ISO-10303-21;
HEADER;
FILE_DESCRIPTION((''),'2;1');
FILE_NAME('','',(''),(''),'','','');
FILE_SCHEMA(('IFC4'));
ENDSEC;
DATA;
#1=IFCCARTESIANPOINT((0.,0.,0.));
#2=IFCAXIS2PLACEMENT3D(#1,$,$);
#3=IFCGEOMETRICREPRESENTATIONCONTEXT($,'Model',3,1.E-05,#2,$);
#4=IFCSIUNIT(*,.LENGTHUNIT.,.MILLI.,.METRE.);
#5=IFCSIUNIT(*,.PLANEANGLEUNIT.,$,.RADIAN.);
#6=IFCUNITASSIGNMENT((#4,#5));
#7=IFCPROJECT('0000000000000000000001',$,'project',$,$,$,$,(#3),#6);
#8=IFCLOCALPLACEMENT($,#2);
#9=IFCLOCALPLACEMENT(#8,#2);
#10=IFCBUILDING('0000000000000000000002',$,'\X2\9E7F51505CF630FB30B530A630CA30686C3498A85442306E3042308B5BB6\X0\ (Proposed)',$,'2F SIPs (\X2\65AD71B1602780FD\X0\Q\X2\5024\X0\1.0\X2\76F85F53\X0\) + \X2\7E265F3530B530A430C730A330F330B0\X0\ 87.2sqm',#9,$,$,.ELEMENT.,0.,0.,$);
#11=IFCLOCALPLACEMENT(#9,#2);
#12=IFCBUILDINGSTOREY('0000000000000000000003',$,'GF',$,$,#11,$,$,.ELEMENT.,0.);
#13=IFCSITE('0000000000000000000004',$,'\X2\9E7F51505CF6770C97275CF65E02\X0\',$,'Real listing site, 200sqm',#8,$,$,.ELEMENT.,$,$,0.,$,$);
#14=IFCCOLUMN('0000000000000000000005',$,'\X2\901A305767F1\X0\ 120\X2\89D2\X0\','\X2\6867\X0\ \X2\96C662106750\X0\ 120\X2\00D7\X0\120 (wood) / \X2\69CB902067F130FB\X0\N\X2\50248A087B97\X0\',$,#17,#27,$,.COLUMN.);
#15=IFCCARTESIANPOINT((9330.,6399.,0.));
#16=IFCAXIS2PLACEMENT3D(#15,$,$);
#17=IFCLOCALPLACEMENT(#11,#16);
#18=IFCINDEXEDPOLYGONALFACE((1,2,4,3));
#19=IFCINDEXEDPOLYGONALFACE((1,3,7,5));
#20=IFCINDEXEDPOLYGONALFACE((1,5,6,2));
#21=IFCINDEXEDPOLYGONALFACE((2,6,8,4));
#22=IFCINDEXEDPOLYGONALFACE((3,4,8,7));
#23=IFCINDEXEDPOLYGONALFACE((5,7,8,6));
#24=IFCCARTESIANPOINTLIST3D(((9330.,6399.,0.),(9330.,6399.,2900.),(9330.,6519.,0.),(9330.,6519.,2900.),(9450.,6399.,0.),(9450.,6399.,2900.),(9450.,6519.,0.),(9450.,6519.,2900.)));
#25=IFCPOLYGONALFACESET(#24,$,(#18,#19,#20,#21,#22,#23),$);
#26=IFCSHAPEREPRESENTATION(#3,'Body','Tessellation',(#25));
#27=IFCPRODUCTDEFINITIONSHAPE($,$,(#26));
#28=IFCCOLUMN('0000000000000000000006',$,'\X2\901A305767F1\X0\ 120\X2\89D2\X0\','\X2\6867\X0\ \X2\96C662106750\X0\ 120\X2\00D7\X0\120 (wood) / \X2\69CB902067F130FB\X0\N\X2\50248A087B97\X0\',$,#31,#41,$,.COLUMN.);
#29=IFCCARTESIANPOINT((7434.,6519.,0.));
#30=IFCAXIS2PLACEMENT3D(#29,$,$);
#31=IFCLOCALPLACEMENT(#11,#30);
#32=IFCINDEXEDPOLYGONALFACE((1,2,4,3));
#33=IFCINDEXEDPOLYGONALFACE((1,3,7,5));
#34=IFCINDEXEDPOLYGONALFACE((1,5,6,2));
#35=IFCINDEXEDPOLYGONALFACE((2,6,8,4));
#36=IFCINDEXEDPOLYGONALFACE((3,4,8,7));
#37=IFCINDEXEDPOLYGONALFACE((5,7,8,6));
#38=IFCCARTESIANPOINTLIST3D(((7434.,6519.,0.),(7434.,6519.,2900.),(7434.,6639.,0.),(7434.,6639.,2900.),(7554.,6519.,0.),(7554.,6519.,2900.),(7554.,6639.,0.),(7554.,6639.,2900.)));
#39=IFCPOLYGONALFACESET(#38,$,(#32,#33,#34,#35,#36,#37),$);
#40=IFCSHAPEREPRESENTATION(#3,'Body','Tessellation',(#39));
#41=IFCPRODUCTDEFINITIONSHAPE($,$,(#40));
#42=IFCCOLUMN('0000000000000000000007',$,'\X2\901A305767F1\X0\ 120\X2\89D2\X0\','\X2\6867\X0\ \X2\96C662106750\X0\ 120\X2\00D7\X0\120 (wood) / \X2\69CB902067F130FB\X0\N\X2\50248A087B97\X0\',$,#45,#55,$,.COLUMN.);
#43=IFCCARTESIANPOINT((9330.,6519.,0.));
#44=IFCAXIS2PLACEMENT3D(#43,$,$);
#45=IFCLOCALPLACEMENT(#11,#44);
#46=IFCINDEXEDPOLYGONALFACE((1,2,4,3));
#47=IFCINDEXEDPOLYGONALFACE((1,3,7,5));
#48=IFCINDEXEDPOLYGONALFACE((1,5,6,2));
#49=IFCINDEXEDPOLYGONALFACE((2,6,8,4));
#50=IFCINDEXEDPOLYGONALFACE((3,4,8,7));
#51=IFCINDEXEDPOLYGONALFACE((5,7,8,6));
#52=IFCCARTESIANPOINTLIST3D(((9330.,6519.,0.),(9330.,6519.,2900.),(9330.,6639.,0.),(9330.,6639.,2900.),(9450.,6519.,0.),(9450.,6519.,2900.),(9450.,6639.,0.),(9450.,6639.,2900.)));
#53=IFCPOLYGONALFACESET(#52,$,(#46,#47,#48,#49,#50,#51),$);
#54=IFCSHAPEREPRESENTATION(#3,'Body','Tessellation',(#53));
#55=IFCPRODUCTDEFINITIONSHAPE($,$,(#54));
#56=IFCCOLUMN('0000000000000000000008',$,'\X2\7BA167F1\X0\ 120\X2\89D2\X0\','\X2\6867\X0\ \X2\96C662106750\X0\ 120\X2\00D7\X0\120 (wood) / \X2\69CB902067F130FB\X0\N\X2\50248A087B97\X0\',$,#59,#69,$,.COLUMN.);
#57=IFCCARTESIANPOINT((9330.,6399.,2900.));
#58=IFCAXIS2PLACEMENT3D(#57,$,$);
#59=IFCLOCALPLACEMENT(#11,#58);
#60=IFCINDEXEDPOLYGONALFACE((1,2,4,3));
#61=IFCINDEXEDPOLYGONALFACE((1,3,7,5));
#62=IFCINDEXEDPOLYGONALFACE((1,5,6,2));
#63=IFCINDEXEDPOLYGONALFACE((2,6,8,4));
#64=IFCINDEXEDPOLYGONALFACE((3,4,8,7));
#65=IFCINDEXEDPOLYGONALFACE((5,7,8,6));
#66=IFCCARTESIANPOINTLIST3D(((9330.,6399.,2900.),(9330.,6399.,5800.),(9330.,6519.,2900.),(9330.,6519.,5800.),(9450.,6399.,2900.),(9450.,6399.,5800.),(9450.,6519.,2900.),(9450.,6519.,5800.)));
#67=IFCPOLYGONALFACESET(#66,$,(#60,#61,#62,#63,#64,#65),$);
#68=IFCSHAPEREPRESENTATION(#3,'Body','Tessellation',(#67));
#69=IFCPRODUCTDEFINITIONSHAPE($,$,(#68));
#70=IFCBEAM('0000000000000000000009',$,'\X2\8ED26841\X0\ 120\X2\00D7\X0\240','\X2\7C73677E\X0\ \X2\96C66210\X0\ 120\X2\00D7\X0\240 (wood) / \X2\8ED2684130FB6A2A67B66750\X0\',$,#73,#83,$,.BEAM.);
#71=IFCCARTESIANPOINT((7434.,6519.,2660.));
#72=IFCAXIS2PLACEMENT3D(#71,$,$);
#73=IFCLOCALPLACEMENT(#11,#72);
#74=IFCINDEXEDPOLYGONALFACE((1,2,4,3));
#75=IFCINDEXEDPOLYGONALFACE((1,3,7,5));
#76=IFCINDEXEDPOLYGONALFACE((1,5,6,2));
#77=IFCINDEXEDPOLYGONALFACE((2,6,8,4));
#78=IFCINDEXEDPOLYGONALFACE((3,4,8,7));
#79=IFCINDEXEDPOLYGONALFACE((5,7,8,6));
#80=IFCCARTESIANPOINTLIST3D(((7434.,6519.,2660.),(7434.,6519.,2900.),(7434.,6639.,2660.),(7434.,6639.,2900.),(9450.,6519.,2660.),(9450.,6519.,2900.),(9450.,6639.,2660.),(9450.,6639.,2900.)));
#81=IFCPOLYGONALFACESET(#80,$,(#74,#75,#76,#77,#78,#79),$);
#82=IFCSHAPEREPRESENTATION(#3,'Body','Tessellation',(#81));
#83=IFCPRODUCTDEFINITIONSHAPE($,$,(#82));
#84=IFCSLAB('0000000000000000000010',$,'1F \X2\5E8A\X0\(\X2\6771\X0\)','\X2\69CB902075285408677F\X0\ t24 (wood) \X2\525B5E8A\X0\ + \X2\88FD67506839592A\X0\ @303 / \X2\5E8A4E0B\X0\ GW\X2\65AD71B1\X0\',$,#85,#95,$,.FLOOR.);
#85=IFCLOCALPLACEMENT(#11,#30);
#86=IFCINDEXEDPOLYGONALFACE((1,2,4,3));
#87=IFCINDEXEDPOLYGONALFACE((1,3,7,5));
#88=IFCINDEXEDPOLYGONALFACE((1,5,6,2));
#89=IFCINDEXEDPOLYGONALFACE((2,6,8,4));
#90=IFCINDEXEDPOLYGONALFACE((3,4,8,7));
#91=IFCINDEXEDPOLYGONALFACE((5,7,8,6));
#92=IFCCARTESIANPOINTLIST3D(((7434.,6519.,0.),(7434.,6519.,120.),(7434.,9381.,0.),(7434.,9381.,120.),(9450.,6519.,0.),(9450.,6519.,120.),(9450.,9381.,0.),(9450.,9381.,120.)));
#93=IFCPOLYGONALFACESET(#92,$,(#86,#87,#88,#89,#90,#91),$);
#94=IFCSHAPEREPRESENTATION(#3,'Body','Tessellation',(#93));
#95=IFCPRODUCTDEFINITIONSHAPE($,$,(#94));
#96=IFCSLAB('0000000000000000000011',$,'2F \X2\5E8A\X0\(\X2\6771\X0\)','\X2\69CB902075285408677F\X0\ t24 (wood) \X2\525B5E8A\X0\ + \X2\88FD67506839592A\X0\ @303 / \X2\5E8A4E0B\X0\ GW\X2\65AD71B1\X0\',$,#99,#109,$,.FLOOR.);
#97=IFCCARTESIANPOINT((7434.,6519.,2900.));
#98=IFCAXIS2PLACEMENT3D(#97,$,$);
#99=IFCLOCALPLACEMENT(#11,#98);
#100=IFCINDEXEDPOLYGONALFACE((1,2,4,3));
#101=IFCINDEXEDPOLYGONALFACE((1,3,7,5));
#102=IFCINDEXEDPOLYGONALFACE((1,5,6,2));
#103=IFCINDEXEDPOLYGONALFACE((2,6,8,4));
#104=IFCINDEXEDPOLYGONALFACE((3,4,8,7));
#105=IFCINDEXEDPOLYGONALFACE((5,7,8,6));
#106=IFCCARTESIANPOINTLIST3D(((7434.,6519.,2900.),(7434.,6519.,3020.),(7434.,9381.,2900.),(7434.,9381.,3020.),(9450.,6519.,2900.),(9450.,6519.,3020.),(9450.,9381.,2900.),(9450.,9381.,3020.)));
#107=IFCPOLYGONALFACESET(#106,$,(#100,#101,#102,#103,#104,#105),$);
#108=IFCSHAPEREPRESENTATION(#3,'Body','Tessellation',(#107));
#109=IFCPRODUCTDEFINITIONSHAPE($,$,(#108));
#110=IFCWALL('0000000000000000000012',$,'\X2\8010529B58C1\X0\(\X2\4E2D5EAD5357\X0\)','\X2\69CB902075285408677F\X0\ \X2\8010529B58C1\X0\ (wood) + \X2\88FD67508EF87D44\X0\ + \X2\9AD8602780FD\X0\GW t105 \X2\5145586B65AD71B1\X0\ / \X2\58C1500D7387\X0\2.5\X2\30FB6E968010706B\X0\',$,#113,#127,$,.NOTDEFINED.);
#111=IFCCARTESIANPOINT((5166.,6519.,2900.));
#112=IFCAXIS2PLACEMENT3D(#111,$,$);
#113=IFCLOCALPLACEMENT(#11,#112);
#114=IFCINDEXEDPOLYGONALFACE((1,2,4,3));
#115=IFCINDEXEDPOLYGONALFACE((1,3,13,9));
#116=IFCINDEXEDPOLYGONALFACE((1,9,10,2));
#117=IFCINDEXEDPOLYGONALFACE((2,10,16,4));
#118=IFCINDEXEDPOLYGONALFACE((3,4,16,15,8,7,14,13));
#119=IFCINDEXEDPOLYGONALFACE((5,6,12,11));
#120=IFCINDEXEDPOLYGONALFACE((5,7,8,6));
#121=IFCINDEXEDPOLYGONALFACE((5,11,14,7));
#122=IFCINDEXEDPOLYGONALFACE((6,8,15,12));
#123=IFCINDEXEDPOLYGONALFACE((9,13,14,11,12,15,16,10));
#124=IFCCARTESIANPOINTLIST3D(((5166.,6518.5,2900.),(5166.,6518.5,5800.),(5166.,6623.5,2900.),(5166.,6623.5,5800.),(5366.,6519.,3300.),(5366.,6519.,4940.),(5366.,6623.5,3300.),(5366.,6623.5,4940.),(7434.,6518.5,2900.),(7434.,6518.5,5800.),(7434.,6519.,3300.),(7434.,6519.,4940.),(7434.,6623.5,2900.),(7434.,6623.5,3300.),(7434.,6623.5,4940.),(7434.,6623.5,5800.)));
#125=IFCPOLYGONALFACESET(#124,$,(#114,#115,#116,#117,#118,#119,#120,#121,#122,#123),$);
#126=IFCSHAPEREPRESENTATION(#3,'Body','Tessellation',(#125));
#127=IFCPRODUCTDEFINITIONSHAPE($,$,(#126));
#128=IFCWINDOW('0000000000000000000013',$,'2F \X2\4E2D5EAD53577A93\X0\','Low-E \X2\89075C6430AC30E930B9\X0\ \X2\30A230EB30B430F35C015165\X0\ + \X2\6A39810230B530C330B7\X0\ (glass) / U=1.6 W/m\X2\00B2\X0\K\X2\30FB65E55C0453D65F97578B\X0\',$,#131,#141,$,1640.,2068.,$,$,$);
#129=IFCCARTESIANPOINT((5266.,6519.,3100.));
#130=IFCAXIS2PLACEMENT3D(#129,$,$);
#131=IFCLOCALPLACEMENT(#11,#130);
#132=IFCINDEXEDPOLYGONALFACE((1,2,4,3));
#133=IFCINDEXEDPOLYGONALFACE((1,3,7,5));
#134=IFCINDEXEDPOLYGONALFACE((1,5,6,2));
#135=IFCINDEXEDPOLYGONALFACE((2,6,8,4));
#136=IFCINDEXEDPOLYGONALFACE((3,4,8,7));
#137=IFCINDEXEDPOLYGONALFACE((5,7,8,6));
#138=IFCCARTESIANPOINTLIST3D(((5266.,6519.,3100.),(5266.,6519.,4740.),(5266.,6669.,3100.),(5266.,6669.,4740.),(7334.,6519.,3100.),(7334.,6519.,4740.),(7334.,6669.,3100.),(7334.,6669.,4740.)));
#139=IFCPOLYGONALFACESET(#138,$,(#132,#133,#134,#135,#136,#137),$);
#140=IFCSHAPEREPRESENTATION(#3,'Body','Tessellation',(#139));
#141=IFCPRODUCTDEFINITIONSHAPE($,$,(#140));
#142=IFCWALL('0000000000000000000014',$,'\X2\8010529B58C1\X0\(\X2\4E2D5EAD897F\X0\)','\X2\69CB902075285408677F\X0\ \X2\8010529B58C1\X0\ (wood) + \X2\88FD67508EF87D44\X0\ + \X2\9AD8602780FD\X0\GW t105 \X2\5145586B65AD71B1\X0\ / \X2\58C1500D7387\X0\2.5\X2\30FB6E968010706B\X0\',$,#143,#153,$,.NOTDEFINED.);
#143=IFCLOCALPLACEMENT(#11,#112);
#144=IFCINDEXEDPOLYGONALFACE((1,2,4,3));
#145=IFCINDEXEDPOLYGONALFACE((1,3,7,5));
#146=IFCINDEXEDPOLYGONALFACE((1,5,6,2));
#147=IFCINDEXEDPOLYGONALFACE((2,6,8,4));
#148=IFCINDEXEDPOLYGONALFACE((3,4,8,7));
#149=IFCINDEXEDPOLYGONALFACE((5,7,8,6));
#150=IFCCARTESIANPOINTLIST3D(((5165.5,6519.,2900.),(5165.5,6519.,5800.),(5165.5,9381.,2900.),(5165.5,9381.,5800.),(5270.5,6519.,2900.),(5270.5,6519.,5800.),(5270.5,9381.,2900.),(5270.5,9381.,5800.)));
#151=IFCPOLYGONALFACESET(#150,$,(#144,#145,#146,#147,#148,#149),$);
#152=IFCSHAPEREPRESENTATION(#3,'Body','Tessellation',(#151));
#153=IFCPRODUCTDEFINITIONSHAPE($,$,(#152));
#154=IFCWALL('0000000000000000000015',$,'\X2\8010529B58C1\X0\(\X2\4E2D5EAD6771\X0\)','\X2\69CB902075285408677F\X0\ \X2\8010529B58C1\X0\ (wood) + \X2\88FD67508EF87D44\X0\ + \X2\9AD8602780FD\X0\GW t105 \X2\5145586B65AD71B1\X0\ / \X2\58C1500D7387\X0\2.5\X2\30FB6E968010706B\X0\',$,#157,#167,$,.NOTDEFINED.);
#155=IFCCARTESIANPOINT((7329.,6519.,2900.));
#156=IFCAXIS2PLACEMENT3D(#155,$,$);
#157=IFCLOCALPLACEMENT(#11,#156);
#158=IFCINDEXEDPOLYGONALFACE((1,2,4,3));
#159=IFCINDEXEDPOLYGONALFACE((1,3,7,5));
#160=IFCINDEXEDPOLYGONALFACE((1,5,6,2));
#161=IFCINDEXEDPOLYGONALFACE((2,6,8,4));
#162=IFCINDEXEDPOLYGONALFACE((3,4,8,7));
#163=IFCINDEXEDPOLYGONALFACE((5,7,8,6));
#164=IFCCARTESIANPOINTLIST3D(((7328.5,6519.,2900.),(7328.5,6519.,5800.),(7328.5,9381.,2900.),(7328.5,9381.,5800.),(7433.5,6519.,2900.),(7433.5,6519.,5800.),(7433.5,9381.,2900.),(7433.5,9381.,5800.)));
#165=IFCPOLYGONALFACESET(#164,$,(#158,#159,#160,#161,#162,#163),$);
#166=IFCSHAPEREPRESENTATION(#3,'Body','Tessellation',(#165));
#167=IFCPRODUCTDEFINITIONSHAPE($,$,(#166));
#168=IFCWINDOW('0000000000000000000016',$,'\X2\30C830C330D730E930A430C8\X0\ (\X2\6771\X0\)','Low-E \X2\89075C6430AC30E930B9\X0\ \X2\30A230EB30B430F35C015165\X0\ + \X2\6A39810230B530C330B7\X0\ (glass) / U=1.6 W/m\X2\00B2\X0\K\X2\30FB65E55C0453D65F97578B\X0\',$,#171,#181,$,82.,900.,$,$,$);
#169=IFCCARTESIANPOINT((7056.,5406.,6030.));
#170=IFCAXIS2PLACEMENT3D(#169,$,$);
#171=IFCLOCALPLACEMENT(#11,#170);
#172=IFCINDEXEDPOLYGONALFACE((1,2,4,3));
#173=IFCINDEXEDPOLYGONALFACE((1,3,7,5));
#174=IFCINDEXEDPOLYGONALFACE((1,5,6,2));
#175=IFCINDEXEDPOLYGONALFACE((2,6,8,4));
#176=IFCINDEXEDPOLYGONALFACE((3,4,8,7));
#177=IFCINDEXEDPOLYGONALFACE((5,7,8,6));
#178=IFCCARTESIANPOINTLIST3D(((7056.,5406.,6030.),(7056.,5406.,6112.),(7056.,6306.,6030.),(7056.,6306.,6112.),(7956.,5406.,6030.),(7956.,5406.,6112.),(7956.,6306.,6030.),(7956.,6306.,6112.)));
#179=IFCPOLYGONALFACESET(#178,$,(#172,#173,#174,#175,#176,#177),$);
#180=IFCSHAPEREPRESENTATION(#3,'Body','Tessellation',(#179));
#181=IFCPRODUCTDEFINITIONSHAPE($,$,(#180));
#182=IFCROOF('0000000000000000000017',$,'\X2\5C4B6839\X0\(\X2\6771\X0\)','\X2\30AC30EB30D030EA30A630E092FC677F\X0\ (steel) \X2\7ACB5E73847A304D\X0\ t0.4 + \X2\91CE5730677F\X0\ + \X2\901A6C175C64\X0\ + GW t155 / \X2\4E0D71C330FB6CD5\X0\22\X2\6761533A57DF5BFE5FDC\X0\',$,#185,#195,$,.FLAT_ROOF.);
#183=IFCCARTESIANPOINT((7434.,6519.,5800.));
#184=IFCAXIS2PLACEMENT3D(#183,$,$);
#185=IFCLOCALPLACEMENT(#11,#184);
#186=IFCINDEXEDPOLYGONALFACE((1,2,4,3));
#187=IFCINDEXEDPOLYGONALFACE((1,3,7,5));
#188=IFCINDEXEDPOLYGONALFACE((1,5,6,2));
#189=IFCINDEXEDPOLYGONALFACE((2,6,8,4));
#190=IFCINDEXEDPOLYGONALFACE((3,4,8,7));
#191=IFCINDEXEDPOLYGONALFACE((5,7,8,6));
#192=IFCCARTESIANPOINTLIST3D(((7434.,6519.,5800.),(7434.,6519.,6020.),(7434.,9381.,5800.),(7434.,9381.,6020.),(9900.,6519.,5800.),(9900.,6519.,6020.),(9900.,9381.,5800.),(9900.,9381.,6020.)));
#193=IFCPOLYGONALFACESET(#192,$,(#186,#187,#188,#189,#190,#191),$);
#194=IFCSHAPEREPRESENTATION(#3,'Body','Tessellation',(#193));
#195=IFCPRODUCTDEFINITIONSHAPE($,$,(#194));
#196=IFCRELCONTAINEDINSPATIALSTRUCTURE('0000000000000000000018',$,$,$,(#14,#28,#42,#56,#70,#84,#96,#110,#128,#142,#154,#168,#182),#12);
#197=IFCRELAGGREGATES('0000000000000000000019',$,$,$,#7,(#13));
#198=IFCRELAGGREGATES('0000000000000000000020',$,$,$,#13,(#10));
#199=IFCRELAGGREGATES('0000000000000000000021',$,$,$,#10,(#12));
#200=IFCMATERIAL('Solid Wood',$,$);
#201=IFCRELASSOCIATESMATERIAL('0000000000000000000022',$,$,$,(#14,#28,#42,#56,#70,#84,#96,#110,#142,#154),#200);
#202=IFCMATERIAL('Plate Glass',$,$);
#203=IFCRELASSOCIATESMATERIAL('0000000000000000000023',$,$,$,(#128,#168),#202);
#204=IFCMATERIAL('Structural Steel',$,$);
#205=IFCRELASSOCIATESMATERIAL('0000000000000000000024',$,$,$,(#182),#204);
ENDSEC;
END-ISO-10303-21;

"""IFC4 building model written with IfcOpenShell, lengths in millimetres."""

from ifc_helpers import new_model, si_unit, frame, frame_2d, origin, place, context, project, spatial, rectangle, extrude, material, element, fill, save


model = new_model("IFC4")

# Units and contexts
model_context = context("Model", 3, precision=1e-05, world=origin())
ifc_project = project(units=[si_unit("LENGTHUNIT", "METRE", prefix="MILLI"), si_unit("PLANEANGLEUNIT", "RADIAN")], contexts=[model_context])

# Site, building, storey
site_placement = place(None, origin())
site = spatial("IfcSite", under=ifc_project, at=site_placement, Name="鹿児島県霧島市", ObjectType="Real listing site, 200sqm", CompositionType="ELEMENT", RefElevation=0.0)
building_placement = place(site_placement, origin())
building = spatial("IfcBuilding", under=site, at=building_placement, Name="鹿児島・サウナと水風呂のある家 (Proposed)", ObjectType="2F SIPs (断熱性能Q値1.0相当) + 縦張サイディング 87.2sqm", CompositionType="ELEMENT", ElevationOfRefHeight=0.0, ElevationOfTerrain=0.0)
storey_placement = place(building_placement, origin())
storey = spatial("IfcBuildingStorey", under=building, at=storey_placement, Name="GF", CompositionType="ELEMENT", Elevation=0.0)

# Columns
ifc_material_1 = material(Name="Solid Wood")
column_1_placement = place(storey_placement, frame((9330.0, 6399.0, 0.0)))
element("IfcColumn", 1, at=column_1_placement, inside=storey, material=ifc_material_1, Name="通し柱 120角", Description="桧 集成材 120×120 (wood) / 構造柱・N値計算", PredefinedType="COLUMN", context=model_context, shape_type="SweptSolid", body=[
    extrude(rectangle(XDim=120.0, YDim=120.0, at=frame_2d((60.0, 60.0))), frame((9330.0, 6399.0, 0.0)), (0.0, 0.0, 1.0), 2900.0),
])
column_2_placement = place(storey_placement, frame((7434.0, 6519.0, 0.0)))
element("IfcColumn", 2, at=column_2_placement, inside=storey, material=ifc_material_1, Name="通し柱 120角", Description="桧 集成材 120×120 (wood) / 構造柱・N値計算", PredefinedType="COLUMN", context=model_context, shape_type="SweptSolid", body=[
    extrude(rectangle(XDim=120.0, YDim=120.0, at=frame_2d((60.0, 60.0))), frame((7434.0, 6519.0, 0.0)), (0.0, 0.0, 1.0), 2900.0),
])
column_3_placement = place(storey_placement, frame((9330.0, 6519.0, 0.0)))
element("IfcColumn", 3, at=column_3_placement, inside=storey, material=ifc_material_1, Name="通し柱 120角", Description="桧 集成材 120×120 (wood) / 構造柱・N値計算", PredefinedType="COLUMN", context=model_context, shape_type="SweptSolid", body=[
    extrude(rectangle(XDim=120.0, YDim=120.0, at=frame_2d((60.0, 60.0))), frame((9330.0, 6519.0, 0.0)), (0.0, 0.0, 1.0), 2900.0),
])
column_4_placement = place(storey_placement, frame((9330.0, 6399.0, 2900.0)))
element("IfcColumn", 4, at=column_4_placement, inside=storey, material=ifc_material_1, Name="管柱 120角", Description="桧 集成材 120×120 (wood) / 構造柱・N値計算", PredefinedType="COLUMN", context=model_context, shape_type="SweptSolid", body=[
    extrude(rectangle(XDim=120.0, YDim=120.0, at=frame_2d((60.0, 60.0))), frame((9330.0, 6399.0, 2900.0)), (0.0, 0.0, 1.0), 2900.0),
])

# Beam
beam_1_placement = place(storey_placement, frame((7434.0, 6519.0, 2660.0)))
element("IfcBeam", 5, at=beam_1_placement, inside=storey, material=ifc_material_1, Name="軒桁 120×240", Description="米松 集成 120×240 (wood) / 軒桁・横架材", PredefinedType="BEAM", context=model_context, shape_type="SweptSolid", body=[
    extrude(rectangle(XDim=2016.0, YDim=120.0, at=frame_2d((1008.0, 60.0))), frame((7434.0, 6519.0, 2660.0)), (0.0, 0.0, 1.0), 240.0),
])

# Slabs
slab_1_placement = place(storey_placement, frame((7434.0, 6519.0, 0.0)))
element("IfcSlab", 6, at=slab_1_placement, inside=storey, material=ifc_material_1, Name="1F 床(東)", Description="構造用合板 t24 (wood) 剛床 + 製材根太 @303 / 床下 GW断熱", PredefinedType="FLOOR", context=model_context, shape_type="SweptSolid", body=[
    extrude(rectangle(XDim=2016.0, YDim=2862.0, at=frame_2d((1008.0, 1431.0))), frame((7434.0, 6519.0, 0.0)), (0.0, 0.0, 1.0), 120.0),
])
slab_2_placement = place(storey_placement, frame((7434.0, 6519.0, 2900.0)))
element("IfcSlab", 7, at=slab_2_placement, inside=storey, material=ifc_material_1, Name="2F 床(東)", Description="構造用合板 t24 (wood) 剛床 + 製材根太 @303 / 床下 GW断熱", PredefinedType="FLOOR", context=model_context, shape_type="SweptSolid", body=[
    extrude(rectangle(XDim=2016.0, YDim=2862.0, at=frame_2d((1008.0, 1431.0))), frame((7434.0, 6519.0, 2900.0)), (0.0, 0.0, 1.0), 120.0),
])

# Wall, opening, window
wall_1_placement = place(storey_placement, frame((5166.0, 6519.0, 2900.0)))
wall_1 = element("IfcWall", 8, at=wall_1_placement, inside=storey, material=ifc_material_1, Name="耐力壁(中庭南)", Description="構造用合板 耐力壁 (wood) + 製材軸組 + 高性能GW t105 充填断熱 / 壁倍率2.5・準耐火", PredefinedType="NOTDEFINED", context=model_context, shape_type="SweptSolid", body=[
    extrude(rectangle(XDim=2268.0, YDim=105.0, at=frame_2d((1134.0, 52.0))), frame((5166.0, 6519.0, 2900.0)), (0.0, 0.0, 1.0), 2900.0),
])
opening_placement = place(storey_placement, frame((5266.0, 6519.0, 3100.0)))
opening = element("IfcOpeningElement", 9, at=opening_placement, cuts=wall_1, PredefinedType="NOTDEFINED", context=model_context, shape_type="SweptSolid", body=[
    extrude(rectangle(XDim=2068.0, YDim=150.0, at=frame_2d((1034.0, 75.0))), frame((5266.0, 6519.0, 3100.0)), (0.0, 0.0, 1.0), 1640.0),
])
ifc_material_2 = material(Name="Plate Glass")
window_1_placement = place(storey_placement, frame((5266.0, 6519.0, 3100.0)))
window_1 = element("IfcWindow", 10, at=window_1_placement, inside=storey, material=ifc_material_2, Name="2F 中庭南窓", Description="Low-E 複層ガラス アルゴン封入 + 樹脂サッシ (glass) / U=1.6 W/m²K・日射取得型", OverallHeight=1640.0, OverallWidth=2068.0, context=model_context, shape_type="SweptSolid", body=[
    extrude(rectangle(XDim=2068.0, YDim=150.0, at=frame_2d((1034.0, 75.0))), frame((5266.0, 6519.0, 3100.0)), (0.0, 0.0, 1.0), 1640.0),
])
fill(opening, window_1)

# Walls
wall_2_placement = place(storey_placement, frame((5166.0, 6519.0, 2900.0)))
element("IfcWall", 11, at=wall_2_placement, inside=storey, material=ifc_material_1, Name="耐力壁(中庭西)", Description="構造用合板 耐力壁 (wood) + 製材軸組 + 高性能GW t105 充填断熱 / 壁倍率2.5・準耐火", PredefinedType="NOTDEFINED", context=model_context, shape_type="SweptSolid", body=[
    extrude(rectangle(XDim=105.0, YDim=2862.0, at=frame_2d((52.0, 1431.0))), frame((5166.0, 6519.0, 2900.0)), (0.0, 0.0, 1.0), 2900.0),
])
wall_3_placement = place(storey_placement, frame((7329.0, 6519.0, 2900.0)))
element("IfcWall", 12, at=wall_3_placement, inside=storey, material=ifc_material_1, Name="耐力壁(中庭東)", Description="構造用合板 耐力壁 (wood) + 製材軸組 + 高性能GW t105 充填断熱 / 壁倍率2.5・準耐火", PredefinedType="NOTDEFINED", context=model_context, shape_type="SweptSolid", body=[
    extrude(rectangle(XDim=105.0, YDim=2862.0, at=frame_2d((52.0, 1431.0))), frame((7329.0, 6519.0, 2900.0)), (0.0, 0.0, 1.0), 2900.0),
])

# Window
window_2_placement = place(storey_placement, frame((7056.0, 5406.0, 6030.0)))
element("IfcWindow", 13, at=window_2_placement, inside=storey, material=ifc_material_2, Name="トップライト (東)", Description="Low-E 複層ガラス アルゴン封入 + 樹脂サッシ (glass) / U=1.6 W/m²K・日射取得型", OverallHeight=82.0, OverallWidth=900.0, context=model_context, shape_type="SweptSolid", body=[
    extrude(rectangle(XDim=900.0, YDim=900.0, at=frame_2d((450.0, 450.0))), frame((7056.0, 5406.0, 6030.0)), (0.0, 0.0, 1.0), 82.0),
])

# Roof
ifc_material_3 = material(Name="Structural Steel")
for number, where, name in (
    (14, (7434.0, 6519.0, 5800.0), "屋根(東)"),
):
    element("IfcRoof", number, at=place(storey_placement, frame(where)), inside=storey, material=ifc_material_3, Name=name, Description="ガルバリウム鋼板 (steel) 立平葺き t0.4 + 野地板 + 通気層 + GW t155 / 不燃・法22条区域対応", PredefinedType="FLAT_ROOF", context=model_context, shape_type="SweptSolid", body=[
        extrude(rectangle(XDim=2466.0, YDim=2862.0, at=frame_2d((1233.0, 1431.0))), frame((7434.0, 6519.0, 5800.0)), (0.0, 0.0, 1.0), 220.0),
    ])

save(model, "model.ifc")
